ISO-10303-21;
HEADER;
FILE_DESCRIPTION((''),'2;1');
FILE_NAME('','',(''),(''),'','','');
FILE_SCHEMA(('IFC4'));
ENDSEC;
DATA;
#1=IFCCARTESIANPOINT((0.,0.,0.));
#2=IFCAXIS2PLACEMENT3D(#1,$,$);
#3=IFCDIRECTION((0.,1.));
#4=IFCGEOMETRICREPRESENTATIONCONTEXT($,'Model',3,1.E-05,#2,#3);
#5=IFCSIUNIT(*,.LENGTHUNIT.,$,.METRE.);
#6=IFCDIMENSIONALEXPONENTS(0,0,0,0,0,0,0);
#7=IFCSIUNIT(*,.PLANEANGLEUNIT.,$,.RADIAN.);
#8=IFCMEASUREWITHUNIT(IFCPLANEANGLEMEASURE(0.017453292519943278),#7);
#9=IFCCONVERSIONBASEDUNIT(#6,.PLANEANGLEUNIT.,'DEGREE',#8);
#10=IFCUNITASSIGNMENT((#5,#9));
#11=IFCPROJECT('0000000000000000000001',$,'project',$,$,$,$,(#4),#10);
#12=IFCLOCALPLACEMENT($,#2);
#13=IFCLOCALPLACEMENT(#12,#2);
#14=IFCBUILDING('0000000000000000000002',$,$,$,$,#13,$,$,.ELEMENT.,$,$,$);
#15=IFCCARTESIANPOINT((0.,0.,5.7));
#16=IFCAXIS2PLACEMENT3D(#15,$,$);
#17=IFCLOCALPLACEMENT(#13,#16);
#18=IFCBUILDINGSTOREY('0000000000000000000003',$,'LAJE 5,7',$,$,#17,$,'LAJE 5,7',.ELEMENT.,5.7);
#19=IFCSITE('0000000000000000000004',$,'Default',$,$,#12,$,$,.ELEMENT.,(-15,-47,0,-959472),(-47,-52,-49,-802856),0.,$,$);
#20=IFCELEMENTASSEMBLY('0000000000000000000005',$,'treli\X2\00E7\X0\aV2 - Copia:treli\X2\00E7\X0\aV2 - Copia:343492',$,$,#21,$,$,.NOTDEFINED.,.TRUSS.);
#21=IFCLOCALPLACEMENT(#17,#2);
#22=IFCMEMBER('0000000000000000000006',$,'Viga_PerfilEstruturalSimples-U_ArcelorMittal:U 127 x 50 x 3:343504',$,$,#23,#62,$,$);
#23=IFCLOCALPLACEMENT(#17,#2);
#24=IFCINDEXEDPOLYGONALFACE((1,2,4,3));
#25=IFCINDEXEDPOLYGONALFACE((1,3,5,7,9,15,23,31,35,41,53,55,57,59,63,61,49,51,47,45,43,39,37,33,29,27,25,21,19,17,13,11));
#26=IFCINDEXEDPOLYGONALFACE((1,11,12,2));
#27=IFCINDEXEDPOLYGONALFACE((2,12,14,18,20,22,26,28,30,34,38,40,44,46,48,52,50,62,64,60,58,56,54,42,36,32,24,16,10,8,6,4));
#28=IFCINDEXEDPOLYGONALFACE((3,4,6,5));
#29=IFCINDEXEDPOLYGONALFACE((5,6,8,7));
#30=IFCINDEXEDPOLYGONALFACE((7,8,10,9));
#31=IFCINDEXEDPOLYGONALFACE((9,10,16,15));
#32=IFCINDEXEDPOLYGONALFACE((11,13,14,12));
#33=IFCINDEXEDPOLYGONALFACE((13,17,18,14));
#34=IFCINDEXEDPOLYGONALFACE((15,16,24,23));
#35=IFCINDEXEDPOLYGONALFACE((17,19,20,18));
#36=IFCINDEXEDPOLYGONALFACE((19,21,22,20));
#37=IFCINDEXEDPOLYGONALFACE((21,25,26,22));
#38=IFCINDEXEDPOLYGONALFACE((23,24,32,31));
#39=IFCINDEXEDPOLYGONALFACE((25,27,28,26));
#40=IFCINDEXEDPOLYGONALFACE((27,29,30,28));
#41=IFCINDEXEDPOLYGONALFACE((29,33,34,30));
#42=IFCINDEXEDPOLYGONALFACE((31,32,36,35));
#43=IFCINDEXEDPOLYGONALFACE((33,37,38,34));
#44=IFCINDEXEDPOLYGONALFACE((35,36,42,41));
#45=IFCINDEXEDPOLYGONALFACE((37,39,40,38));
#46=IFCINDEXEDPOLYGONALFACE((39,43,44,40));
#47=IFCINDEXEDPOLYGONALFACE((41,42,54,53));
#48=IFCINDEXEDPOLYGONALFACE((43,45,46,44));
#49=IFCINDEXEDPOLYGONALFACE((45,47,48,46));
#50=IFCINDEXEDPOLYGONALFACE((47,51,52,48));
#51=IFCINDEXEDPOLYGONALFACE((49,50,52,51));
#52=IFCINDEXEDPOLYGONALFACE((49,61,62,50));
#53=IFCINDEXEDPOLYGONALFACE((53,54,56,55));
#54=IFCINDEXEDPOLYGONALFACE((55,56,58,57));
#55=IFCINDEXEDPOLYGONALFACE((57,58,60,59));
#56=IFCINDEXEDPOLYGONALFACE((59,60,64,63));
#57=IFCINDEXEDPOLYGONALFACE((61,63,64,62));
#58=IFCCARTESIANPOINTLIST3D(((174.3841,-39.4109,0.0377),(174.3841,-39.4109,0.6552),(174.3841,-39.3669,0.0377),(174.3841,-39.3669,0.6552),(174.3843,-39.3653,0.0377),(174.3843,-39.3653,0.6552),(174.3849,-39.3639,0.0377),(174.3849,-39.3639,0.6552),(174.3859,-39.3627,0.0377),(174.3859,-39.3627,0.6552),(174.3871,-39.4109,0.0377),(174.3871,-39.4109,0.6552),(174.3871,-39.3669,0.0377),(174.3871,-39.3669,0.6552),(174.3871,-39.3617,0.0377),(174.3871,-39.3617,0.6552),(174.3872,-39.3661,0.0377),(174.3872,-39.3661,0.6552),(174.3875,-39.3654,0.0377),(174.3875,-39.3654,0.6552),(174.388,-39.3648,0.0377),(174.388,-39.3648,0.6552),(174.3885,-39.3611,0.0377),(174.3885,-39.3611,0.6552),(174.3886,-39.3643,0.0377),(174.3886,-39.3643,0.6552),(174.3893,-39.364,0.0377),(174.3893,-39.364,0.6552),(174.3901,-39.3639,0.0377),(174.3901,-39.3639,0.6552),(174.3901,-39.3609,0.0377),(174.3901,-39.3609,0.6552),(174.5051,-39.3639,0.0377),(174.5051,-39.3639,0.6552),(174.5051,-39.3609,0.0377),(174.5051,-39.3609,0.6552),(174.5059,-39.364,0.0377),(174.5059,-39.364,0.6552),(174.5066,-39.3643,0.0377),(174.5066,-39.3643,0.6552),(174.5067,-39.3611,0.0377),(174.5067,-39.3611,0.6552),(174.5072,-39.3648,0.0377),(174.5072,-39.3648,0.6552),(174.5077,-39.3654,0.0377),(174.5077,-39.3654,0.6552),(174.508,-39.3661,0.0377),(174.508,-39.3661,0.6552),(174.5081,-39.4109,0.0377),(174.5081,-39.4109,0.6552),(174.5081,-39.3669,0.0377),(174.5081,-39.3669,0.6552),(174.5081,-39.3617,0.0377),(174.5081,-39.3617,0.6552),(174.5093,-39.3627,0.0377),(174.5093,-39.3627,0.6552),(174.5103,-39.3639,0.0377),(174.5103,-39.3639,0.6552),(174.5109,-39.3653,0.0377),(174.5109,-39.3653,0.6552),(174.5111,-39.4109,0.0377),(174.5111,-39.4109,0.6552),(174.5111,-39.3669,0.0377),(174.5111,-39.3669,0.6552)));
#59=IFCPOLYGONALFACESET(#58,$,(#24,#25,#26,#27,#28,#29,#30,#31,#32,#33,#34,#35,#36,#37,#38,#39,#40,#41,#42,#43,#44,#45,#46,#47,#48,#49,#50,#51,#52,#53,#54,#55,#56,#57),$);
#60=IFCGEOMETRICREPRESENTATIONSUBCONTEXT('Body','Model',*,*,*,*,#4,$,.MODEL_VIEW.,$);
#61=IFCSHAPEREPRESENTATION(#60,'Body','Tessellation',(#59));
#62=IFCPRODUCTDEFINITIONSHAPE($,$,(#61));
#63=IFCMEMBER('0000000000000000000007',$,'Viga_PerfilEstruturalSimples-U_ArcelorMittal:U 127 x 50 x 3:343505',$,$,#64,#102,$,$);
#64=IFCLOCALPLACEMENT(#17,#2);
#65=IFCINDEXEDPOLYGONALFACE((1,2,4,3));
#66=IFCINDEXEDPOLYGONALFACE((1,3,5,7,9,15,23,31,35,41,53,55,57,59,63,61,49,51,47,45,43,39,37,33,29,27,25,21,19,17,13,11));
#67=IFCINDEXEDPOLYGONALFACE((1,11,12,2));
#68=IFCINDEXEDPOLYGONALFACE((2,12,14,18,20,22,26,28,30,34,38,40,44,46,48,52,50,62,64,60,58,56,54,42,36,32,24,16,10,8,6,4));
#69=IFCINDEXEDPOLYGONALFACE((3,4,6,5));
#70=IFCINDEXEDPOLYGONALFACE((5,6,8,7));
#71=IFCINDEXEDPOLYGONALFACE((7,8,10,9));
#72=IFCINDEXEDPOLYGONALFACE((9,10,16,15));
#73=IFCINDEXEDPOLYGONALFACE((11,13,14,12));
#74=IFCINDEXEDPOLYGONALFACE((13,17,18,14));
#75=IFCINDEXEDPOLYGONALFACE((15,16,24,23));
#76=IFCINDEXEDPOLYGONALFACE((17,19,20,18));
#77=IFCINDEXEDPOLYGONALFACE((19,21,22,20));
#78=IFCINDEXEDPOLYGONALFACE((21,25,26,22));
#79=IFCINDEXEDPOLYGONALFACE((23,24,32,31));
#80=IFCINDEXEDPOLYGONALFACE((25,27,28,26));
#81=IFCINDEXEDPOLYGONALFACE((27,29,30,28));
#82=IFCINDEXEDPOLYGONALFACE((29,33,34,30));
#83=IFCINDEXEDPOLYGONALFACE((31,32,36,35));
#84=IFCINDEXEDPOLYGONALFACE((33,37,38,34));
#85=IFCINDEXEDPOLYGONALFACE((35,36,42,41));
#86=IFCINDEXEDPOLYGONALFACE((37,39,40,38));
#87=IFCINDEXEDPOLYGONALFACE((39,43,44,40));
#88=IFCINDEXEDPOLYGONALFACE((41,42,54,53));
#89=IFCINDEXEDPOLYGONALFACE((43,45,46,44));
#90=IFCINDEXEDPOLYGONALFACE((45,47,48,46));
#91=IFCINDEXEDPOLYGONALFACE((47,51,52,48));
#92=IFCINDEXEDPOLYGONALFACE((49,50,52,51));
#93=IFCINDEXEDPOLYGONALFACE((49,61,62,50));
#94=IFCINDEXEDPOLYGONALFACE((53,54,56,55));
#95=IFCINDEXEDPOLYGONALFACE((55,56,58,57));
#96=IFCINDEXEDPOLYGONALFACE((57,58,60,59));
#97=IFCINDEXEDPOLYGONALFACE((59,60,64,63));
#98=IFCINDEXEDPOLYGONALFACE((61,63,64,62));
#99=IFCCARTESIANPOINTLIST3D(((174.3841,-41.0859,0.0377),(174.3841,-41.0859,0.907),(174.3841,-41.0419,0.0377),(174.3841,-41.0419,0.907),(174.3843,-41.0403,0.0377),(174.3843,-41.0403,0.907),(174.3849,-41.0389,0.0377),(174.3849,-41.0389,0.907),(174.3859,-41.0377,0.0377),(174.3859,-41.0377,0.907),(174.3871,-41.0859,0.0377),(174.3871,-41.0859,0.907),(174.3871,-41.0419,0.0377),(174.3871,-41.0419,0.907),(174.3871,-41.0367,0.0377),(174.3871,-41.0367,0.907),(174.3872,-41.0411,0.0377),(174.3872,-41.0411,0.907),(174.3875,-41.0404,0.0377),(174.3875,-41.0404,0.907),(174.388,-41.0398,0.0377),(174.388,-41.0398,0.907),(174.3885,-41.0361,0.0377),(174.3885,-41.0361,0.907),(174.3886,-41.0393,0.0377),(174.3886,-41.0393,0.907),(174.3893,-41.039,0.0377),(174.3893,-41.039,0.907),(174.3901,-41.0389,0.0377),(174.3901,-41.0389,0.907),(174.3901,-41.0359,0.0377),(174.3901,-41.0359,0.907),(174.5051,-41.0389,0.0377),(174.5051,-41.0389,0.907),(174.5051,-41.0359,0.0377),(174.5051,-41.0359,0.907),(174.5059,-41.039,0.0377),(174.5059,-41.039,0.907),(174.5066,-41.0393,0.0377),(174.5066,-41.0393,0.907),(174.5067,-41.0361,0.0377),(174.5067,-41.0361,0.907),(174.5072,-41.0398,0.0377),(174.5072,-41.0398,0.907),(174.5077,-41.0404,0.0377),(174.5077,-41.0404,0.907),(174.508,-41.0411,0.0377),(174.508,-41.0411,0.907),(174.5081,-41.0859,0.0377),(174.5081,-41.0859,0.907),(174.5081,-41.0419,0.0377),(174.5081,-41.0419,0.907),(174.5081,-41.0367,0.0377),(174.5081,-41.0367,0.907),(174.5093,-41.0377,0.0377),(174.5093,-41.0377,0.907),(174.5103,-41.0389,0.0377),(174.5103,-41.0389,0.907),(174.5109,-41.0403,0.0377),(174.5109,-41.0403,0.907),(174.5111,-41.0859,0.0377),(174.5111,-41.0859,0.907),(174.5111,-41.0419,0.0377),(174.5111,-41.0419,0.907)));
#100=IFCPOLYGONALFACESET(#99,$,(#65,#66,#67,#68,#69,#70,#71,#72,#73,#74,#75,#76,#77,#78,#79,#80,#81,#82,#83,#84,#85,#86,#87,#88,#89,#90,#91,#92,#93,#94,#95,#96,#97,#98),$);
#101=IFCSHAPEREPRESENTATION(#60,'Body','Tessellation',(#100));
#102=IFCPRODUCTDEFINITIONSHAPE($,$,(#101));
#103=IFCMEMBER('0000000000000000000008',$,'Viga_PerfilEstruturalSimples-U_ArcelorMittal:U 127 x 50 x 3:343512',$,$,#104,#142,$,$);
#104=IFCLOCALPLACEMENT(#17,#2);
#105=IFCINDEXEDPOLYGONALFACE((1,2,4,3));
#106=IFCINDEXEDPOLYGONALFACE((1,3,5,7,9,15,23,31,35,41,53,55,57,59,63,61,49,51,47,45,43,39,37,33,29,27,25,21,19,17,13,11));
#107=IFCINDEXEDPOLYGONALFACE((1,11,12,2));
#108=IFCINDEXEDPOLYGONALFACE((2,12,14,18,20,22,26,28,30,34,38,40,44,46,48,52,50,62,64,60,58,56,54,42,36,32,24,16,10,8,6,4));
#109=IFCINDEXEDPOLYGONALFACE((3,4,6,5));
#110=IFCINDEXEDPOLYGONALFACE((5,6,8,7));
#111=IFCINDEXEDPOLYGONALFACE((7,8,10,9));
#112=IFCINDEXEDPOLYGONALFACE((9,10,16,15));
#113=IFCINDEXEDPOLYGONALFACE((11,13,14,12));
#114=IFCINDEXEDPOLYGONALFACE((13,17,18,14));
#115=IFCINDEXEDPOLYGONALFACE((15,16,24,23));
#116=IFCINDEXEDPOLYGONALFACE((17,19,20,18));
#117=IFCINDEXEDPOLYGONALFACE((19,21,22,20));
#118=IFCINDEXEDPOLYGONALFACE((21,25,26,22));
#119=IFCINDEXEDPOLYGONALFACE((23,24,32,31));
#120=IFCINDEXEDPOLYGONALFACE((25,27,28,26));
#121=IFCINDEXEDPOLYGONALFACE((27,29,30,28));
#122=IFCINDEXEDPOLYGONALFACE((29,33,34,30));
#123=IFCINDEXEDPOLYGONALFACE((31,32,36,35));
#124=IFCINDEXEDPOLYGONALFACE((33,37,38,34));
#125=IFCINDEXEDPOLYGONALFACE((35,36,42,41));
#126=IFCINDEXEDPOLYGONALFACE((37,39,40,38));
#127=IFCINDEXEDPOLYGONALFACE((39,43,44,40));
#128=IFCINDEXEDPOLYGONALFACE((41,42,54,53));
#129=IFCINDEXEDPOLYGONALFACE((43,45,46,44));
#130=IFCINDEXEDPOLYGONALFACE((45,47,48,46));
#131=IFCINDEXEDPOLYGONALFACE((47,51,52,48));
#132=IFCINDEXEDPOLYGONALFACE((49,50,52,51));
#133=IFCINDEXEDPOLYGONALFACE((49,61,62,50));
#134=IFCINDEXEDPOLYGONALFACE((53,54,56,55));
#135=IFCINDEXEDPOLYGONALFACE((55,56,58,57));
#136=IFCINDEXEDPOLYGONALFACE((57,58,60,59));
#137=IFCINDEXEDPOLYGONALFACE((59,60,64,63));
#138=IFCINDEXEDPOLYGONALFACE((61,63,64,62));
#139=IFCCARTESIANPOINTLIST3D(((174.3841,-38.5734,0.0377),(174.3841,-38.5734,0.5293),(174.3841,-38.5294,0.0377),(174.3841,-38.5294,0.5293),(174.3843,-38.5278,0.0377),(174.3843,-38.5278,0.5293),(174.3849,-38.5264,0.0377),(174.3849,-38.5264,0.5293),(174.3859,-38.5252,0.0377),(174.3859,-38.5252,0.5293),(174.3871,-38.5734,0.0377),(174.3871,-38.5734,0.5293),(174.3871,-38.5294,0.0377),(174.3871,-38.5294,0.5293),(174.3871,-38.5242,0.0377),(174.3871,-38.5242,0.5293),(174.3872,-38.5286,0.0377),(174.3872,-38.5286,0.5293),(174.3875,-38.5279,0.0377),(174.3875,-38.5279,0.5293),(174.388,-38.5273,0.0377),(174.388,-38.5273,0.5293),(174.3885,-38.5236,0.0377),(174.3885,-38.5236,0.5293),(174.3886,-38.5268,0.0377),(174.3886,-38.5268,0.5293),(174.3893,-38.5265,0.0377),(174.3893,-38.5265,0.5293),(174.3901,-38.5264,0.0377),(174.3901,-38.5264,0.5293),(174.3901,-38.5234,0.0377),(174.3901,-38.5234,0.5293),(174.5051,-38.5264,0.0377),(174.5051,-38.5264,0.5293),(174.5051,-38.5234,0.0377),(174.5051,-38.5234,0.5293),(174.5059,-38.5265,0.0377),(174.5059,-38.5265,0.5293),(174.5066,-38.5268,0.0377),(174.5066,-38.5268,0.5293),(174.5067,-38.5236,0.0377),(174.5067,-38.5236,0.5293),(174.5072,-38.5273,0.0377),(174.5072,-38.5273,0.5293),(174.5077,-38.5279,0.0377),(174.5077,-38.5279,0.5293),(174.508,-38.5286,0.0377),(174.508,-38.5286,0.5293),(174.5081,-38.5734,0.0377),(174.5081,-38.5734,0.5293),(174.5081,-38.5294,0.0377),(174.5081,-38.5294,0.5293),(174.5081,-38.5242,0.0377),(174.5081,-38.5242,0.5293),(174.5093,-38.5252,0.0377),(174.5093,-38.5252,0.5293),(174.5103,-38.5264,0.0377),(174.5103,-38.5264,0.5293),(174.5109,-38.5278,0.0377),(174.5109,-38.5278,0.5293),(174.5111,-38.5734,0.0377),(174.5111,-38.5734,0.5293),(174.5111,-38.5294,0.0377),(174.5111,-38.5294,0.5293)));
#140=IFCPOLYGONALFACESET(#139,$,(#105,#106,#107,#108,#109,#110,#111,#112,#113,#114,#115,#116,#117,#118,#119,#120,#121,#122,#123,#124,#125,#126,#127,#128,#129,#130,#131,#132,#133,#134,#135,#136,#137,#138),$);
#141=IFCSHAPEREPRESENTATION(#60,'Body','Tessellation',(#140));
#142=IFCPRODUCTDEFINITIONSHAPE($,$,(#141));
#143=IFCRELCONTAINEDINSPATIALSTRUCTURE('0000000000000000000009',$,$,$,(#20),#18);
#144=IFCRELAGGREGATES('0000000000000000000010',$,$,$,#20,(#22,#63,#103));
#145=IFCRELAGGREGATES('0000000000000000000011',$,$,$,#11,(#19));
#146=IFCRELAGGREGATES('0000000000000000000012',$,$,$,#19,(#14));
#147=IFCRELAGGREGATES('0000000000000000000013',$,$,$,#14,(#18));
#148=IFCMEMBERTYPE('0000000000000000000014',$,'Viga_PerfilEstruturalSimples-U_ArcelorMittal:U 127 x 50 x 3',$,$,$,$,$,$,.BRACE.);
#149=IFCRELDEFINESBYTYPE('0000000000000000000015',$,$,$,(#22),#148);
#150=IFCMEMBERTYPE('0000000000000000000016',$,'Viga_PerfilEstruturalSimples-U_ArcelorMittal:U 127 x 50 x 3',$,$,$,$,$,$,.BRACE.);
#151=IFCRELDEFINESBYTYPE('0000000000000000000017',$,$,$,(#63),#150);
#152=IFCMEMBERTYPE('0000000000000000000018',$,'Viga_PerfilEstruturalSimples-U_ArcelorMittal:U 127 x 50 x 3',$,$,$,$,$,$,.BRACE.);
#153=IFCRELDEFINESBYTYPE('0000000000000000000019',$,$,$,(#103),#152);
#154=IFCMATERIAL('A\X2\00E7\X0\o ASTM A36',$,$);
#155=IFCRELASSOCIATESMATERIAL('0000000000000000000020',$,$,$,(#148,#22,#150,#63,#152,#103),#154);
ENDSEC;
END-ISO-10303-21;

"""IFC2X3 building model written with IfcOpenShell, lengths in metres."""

from ifc_helpers import new_model, entity, si_unit, converted_unit, direction, frame, frame_2d, origin, place, context, subcontext, project, spatial, polyline, circle_curve, parameter, trimmed, segment, composite_curve, outline, extrude, source, transform, mapped, material, type_object, type_shapes, element, aggregate, save


model = new_model("IFC2X3")

# Units and contexts
model_context = context("Model", 3, precision=1e-05, world=origin(), true_north=direction((0.0, 1.0)))
body_context = subcontext(model_context, "Body", "Model", "MODEL_VIEW")
ifc_project = project(units=[si_unit("LENGTHUNIT", "METRE"), converted_unit("PLANEANGLEUNIT", "DEGREE", entity("IfcPlaneAngleMeasure", 0.017453292519943278), si_unit("PLANEANGLEUNIT", "RADIAN"), dimensions=[0, 0, 0, 0, 0, 0, 0])], contexts=[model_context])

# Site, building, storey
site_placement = place(None, origin())
site = spatial("IfcSite", under=ifc_project, at=site_placement, Name="Default", CompositionType="ELEMENT", RefLatitude=(-15, -47, 0, -959472), RefLongitude=(-47, -52, -49, -802856), RefElevation=0.0)
building_placement = place(site_placement, origin())
building = spatial("IfcBuilding", under=site, at=building_placement, CompositionType="ELEMENT")
storey_placement = place(building_placement, frame((0.0, 0.0, 5.7)))
storey = spatial("IfcBuildingStorey", under=building, at=storey_placement, Name="LAJE 5,7", LongName="LAJE 5,7", CompositionType="ELEMENT", Elevation=5.7)

# Element assembly, members
assembly_1_placement = place(storey_placement, origin())
assembly_1 = element("IfcElementAssembly", 1, at=assembly_1_placement, inside=storey, Name="treliçaV2 - Copia:treliçaV2 - Copia:343492", AssemblyPlace="NOTDEFINED", PredefinedType="TRUSS")
ifc_material = material(Name="Aço ASTM A36")
member_type_1 = type_object("IfcMemberType", Name="Viga_PerfilEstruturalSimples-U_ArcelorMittal:U 127 x 50 x 3", PredefinedType="BRACE", material=ifc_material)
shared_shape_1 = source(origin(), body_context, "Body", "SweptSolid", [
    extrude(outline(composite_curve([segment(polyline([(-0.0575, -0.0192), (0.0575, -0.0192)]), True, "CONTINUOUS"), segment(trimmed(circle_curve(frame_2d((0.0575, -0.0132), x_axis=(0.0, 1.0)), 0.006), [parameter(180.0)], [parameter(270.0)], True, "PARAMETER"), True, "CONTINUOUS"), segment(polyline([(0.0635, -0.0132), (0.0635, 0.0308)]), True, "CONTINUOUS"), segment(polyline([(0.0635, 0.0308), (0.0605, 0.0308)]), True, "CONTINUOUS"), segment(polyline([(0.0605, 0.0308), (0.0605, -0.0132)]), True, "CONTINUOUS"), segment(trimmed(circle_curve(frame_2d((0.0575, -0.0132), x_axis=(0.0, 1.0)), 0.003), [parameter(180.0)], [parameter(270.0)], True, "PARAMETER"), False, "CONTINUOUS"), segment(polyline([(0.0575, -0.0162), (-0.0575, -0.0162)]), True, "CONTINUOUS"), segment(trimmed(circle_curve(frame_2d((-0.0575, -0.0132), x_axis=(0.0, 1.0)), 0.003), [parameter(90.0)], [parameter(180.0)], True, "PARAMETER"), False, "CONTINUOUS"), segment(polyline([(-0.0605, -0.0132), (-0.0605, 0.0308)]), True, "CONTINUOUS"), segment(polyline([(-0.0605, 0.0308), (-0.0635, 0.0308)]), True, "CONTINUOUS"), segment(polyline([(-0.0635, 0.0308), (-0.0635, -0.0132)]), True, "CONTINUOUS"), segment(trimmed(circle_curve(frame_2d((-0.0575, -0.0132), x_axis=(0.0, 1.0)), 0.006), [parameter(90.0)], [parameter(180.0)], True, "PARAMETER"), True, "CONTINUOUS")], self_intersect=False)), frame((-0.3108, -0.0058, 0.0), z_axis=(1.0, 0.0, 0.0), x_axis=(0.0, 0.0, -1.0)), (0.0, 0.0, 1.0), 0.6175),
])
type_shapes(member_type_1, [shared_shape_1])
member_1_placement = place(assembly_1_placement, frame((174.4476, -39.3859, 0.3485), z_axis=(1.0, 0.0, 0.0), x_axis=(0.0, 0.0, 1.0)))
member_1 = element("IfcMember", 2, at=member_1_placement, type_object=member_type_1, material=ifc_material, Name="Viga_PerfilEstruturalSimples-U_ArcelorMittal:U 127 x 50 x 3:343504", context=body_context, shape_type="MappedRepresentation", body=[
    mapped(shared_shape_1, transform((0.0, 0.0, 0.0), scale=1.0)),
])
member_type_2 = type_object("IfcMemberType", Name="Viga_PerfilEstruturalSimples-U_ArcelorMittal:U 127 x 50 x 3", PredefinedType="BRACE", material=ifc_material)
shared_shape_2 = source(origin(), body_context, "Body", "SweptSolid", [
    extrude(outline(composite_curve([segment(polyline([(-0.0575, -0.0192), (0.0575, -0.0192)]), True, "CONTINUOUS"), segment(trimmed(circle_curve(frame_2d((0.0575, -0.0132), x_axis=(0.0, 1.0)), 0.006), [parameter(180.0)], [parameter(270.0)], True, "PARAMETER"), True, "CONTINUOUS"), segment(polyline([(0.0635, -0.0132), (0.0635, 0.0308)]), True, "CONTINUOUS"), segment(polyline([(0.0635, 0.0308), (0.0605, 0.0308)]), True, "CONTINUOUS"), segment(polyline([(0.0605, 0.0308), (0.0605, -0.0132)]), True, "CONTINUOUS"), segment(trimmed(circle_curve(frame_2d((0.0575, -0.0132), x_axis=(0.0, 1.0)), 0.003), [parameter(180.0)], [parameter(270.0)], True, "PARAMETER"), False, "CONTINUOUS"), segment(polyline([(0.0575, -0.0162), (-0.0575, -0.0162)]), True, "CONTINUOUS"), segment(trimmed(circle_curve(frame_2d((-0.0575, -0.0132), x_axis=(0.0, 1.0)), 0.003), [parameter(90.0)], [parameter(180.0)], True, "PARAMETER"), False, "CONTINUOUS"), segment(polyline([(-0.0605, -0.0132), (-0.0605, 0.0308)]), True, "CONTINUOUS"), segment(polyline([(-0.0605, 0.0308), (-0.0635, 0.0308)]), True, "CONTINUOUS"), segment(polyline([(-0.0635, 0.0308), (-0.0635, -0.0132)]), True, "CONTINUOUS"), segment(trimmed(circle_curve(frame_2d((-0.0575, -0.0132), x_axis=(0.0, 1.0)), 0.006), [parameter(90.0)], [parameter(180.0)], True, "PARAMETER"), True, "CONTINUOUS")], self_intersect=False)), frame((-0.4367, -0.0058, 0.0), z_axis=(1.0, 0.0, 0.0), x_axis=(0.0, 0.0, -1.0)), (0.0, 0.0, 1.0), 0.8693),
])
type_shapes(member_type_2, [shared_shape_2])
member_2_placement = place(assembly_1_placement, frame((174.4476, -41.0609, 0.4744), z_axis=(1.0, 0.0, 0.0), x_axis=(0.0, 0.0, 1.0)))
member_2 = element("IfcMember", 3, at=member_2_placement, type_object=member_type_2, material=ifc_material, Name="Viga_PerfilEstruturalSimples-U_ArcelorMittal:U 127 x 50 x 3:343505", context=body_context, shape_type="MappedRepresentation", body=[
    mapped(shared_shape_2, transform((0.0, 0.0, 0.0), scale=1.0)),
])

# Shared definitions
member_type_3 = type_object("IfcMemberType", Name="Viga_PerfilEstruturalSimples-U_ArcelorMittal:U 127 x 50 x 3", PredefinedType="BRACE", material=ifc_material)
shared_shape_3 = source(origin(), body_context, "Body", "SweptSolid", [
    extrude(outline(composite_curve([segment(polyline([(-0.0575, -0.0192), (0.0575, -0.0192)]), True, "CONTINUOUS"), segment(trimmed(circle_curve(frame_2d((0.0575, -0.0132), x_axis=(0.0, 1.0)), 0.006), [parameter(180.0)], [parameter(270.0)], True, "PARAMETER"), True, "CONTINUOUS"), segment(polyline([(0.0635, -0.0132), (0.0635, 0.0308)]), True, "CONTINUOUS"), segment(polyline([(0.0635, 0.0308), (0.0605, 0.0308)]), True, "CONTINUOUS"), segment(polyline([(0.0605, 0.0308), (0.0605, -0.0132)]), True, "CONTINUOUS"), segment(trimmed(circle_curve(frame_2d((0.0575, -0.0132), x_axis=(0.0, 1.0)), 0.003), [parameter(180.0)], [parameter(270.0)], True, "PARAMETER"), False, "CONTINUOUS"), segment(polyline([(0.0575, -0.0162), (-0.0575, -0.0162)]), True, "CONTINUOUS"), segment(trimmed(circle_curve(frame_2d((-0.0575, -0.0132), x_axis=(0.0, 1.0)), 0.003), [parameter(90.0)], [parameter(180.0)], True, "PARAMETER"), False, "CONTINUOUS"), segment(polyline([(-0.0605, -0.0132), (-0.0605, 0.0308)]), True, "CONTINUOUS"), segment(polyline([(-0.0605, 0.0308), (-0.0635, 0.0308)]), True, "CONTINUOUS"), segment(polyline([(-0.0635, 0.0308), (-0.0635, -0.0132)]), True, "CONTINUOUS"), segment(trimmed(circle_curve(frame_2d((-0.0575, -0.0132), x_axis=(0.0, 1.0)), 0.006), [parameter(90.0)], [parameter(180.0)], True, "PARAMETER"), True, "CONTINUOUS")], self_intersect=False)), frame((-0.2478, -0.0058, 0.0), z_axis=(1.0, 0.0, 0.0), x_axis=(0.0, 0.0, -1.0)), (0.0, 0.0, 1.0), 0.4916),
])
type_shapes(member_type_3, [shared_shape_3])

# Member
member_3_placement = place(assembly_1_placement, frame((174.4476, -38.5484, 0.2855), z_axis=(1.0, 0.0, 0.0), x_axis=(0.0, 0.0, 1.0)))
member_3 = element("IfcMember", 4, at=member_3_placement, type_object=member_type_3, material=ifc_material, Name="Viga_PerfilEstruturalSimples-U_ArcelorMittal:U 127 x 50 x 3:343512", context=body_context, shape_type="MappedRepresentation", body=[
    mapped(shared_shape_3, transform((0.0, 0.0, 0.0), scale=1.0)),
])
aggregate(assembly_1, [member_1, member_2, member_3])

save(model, "model.ifc")
